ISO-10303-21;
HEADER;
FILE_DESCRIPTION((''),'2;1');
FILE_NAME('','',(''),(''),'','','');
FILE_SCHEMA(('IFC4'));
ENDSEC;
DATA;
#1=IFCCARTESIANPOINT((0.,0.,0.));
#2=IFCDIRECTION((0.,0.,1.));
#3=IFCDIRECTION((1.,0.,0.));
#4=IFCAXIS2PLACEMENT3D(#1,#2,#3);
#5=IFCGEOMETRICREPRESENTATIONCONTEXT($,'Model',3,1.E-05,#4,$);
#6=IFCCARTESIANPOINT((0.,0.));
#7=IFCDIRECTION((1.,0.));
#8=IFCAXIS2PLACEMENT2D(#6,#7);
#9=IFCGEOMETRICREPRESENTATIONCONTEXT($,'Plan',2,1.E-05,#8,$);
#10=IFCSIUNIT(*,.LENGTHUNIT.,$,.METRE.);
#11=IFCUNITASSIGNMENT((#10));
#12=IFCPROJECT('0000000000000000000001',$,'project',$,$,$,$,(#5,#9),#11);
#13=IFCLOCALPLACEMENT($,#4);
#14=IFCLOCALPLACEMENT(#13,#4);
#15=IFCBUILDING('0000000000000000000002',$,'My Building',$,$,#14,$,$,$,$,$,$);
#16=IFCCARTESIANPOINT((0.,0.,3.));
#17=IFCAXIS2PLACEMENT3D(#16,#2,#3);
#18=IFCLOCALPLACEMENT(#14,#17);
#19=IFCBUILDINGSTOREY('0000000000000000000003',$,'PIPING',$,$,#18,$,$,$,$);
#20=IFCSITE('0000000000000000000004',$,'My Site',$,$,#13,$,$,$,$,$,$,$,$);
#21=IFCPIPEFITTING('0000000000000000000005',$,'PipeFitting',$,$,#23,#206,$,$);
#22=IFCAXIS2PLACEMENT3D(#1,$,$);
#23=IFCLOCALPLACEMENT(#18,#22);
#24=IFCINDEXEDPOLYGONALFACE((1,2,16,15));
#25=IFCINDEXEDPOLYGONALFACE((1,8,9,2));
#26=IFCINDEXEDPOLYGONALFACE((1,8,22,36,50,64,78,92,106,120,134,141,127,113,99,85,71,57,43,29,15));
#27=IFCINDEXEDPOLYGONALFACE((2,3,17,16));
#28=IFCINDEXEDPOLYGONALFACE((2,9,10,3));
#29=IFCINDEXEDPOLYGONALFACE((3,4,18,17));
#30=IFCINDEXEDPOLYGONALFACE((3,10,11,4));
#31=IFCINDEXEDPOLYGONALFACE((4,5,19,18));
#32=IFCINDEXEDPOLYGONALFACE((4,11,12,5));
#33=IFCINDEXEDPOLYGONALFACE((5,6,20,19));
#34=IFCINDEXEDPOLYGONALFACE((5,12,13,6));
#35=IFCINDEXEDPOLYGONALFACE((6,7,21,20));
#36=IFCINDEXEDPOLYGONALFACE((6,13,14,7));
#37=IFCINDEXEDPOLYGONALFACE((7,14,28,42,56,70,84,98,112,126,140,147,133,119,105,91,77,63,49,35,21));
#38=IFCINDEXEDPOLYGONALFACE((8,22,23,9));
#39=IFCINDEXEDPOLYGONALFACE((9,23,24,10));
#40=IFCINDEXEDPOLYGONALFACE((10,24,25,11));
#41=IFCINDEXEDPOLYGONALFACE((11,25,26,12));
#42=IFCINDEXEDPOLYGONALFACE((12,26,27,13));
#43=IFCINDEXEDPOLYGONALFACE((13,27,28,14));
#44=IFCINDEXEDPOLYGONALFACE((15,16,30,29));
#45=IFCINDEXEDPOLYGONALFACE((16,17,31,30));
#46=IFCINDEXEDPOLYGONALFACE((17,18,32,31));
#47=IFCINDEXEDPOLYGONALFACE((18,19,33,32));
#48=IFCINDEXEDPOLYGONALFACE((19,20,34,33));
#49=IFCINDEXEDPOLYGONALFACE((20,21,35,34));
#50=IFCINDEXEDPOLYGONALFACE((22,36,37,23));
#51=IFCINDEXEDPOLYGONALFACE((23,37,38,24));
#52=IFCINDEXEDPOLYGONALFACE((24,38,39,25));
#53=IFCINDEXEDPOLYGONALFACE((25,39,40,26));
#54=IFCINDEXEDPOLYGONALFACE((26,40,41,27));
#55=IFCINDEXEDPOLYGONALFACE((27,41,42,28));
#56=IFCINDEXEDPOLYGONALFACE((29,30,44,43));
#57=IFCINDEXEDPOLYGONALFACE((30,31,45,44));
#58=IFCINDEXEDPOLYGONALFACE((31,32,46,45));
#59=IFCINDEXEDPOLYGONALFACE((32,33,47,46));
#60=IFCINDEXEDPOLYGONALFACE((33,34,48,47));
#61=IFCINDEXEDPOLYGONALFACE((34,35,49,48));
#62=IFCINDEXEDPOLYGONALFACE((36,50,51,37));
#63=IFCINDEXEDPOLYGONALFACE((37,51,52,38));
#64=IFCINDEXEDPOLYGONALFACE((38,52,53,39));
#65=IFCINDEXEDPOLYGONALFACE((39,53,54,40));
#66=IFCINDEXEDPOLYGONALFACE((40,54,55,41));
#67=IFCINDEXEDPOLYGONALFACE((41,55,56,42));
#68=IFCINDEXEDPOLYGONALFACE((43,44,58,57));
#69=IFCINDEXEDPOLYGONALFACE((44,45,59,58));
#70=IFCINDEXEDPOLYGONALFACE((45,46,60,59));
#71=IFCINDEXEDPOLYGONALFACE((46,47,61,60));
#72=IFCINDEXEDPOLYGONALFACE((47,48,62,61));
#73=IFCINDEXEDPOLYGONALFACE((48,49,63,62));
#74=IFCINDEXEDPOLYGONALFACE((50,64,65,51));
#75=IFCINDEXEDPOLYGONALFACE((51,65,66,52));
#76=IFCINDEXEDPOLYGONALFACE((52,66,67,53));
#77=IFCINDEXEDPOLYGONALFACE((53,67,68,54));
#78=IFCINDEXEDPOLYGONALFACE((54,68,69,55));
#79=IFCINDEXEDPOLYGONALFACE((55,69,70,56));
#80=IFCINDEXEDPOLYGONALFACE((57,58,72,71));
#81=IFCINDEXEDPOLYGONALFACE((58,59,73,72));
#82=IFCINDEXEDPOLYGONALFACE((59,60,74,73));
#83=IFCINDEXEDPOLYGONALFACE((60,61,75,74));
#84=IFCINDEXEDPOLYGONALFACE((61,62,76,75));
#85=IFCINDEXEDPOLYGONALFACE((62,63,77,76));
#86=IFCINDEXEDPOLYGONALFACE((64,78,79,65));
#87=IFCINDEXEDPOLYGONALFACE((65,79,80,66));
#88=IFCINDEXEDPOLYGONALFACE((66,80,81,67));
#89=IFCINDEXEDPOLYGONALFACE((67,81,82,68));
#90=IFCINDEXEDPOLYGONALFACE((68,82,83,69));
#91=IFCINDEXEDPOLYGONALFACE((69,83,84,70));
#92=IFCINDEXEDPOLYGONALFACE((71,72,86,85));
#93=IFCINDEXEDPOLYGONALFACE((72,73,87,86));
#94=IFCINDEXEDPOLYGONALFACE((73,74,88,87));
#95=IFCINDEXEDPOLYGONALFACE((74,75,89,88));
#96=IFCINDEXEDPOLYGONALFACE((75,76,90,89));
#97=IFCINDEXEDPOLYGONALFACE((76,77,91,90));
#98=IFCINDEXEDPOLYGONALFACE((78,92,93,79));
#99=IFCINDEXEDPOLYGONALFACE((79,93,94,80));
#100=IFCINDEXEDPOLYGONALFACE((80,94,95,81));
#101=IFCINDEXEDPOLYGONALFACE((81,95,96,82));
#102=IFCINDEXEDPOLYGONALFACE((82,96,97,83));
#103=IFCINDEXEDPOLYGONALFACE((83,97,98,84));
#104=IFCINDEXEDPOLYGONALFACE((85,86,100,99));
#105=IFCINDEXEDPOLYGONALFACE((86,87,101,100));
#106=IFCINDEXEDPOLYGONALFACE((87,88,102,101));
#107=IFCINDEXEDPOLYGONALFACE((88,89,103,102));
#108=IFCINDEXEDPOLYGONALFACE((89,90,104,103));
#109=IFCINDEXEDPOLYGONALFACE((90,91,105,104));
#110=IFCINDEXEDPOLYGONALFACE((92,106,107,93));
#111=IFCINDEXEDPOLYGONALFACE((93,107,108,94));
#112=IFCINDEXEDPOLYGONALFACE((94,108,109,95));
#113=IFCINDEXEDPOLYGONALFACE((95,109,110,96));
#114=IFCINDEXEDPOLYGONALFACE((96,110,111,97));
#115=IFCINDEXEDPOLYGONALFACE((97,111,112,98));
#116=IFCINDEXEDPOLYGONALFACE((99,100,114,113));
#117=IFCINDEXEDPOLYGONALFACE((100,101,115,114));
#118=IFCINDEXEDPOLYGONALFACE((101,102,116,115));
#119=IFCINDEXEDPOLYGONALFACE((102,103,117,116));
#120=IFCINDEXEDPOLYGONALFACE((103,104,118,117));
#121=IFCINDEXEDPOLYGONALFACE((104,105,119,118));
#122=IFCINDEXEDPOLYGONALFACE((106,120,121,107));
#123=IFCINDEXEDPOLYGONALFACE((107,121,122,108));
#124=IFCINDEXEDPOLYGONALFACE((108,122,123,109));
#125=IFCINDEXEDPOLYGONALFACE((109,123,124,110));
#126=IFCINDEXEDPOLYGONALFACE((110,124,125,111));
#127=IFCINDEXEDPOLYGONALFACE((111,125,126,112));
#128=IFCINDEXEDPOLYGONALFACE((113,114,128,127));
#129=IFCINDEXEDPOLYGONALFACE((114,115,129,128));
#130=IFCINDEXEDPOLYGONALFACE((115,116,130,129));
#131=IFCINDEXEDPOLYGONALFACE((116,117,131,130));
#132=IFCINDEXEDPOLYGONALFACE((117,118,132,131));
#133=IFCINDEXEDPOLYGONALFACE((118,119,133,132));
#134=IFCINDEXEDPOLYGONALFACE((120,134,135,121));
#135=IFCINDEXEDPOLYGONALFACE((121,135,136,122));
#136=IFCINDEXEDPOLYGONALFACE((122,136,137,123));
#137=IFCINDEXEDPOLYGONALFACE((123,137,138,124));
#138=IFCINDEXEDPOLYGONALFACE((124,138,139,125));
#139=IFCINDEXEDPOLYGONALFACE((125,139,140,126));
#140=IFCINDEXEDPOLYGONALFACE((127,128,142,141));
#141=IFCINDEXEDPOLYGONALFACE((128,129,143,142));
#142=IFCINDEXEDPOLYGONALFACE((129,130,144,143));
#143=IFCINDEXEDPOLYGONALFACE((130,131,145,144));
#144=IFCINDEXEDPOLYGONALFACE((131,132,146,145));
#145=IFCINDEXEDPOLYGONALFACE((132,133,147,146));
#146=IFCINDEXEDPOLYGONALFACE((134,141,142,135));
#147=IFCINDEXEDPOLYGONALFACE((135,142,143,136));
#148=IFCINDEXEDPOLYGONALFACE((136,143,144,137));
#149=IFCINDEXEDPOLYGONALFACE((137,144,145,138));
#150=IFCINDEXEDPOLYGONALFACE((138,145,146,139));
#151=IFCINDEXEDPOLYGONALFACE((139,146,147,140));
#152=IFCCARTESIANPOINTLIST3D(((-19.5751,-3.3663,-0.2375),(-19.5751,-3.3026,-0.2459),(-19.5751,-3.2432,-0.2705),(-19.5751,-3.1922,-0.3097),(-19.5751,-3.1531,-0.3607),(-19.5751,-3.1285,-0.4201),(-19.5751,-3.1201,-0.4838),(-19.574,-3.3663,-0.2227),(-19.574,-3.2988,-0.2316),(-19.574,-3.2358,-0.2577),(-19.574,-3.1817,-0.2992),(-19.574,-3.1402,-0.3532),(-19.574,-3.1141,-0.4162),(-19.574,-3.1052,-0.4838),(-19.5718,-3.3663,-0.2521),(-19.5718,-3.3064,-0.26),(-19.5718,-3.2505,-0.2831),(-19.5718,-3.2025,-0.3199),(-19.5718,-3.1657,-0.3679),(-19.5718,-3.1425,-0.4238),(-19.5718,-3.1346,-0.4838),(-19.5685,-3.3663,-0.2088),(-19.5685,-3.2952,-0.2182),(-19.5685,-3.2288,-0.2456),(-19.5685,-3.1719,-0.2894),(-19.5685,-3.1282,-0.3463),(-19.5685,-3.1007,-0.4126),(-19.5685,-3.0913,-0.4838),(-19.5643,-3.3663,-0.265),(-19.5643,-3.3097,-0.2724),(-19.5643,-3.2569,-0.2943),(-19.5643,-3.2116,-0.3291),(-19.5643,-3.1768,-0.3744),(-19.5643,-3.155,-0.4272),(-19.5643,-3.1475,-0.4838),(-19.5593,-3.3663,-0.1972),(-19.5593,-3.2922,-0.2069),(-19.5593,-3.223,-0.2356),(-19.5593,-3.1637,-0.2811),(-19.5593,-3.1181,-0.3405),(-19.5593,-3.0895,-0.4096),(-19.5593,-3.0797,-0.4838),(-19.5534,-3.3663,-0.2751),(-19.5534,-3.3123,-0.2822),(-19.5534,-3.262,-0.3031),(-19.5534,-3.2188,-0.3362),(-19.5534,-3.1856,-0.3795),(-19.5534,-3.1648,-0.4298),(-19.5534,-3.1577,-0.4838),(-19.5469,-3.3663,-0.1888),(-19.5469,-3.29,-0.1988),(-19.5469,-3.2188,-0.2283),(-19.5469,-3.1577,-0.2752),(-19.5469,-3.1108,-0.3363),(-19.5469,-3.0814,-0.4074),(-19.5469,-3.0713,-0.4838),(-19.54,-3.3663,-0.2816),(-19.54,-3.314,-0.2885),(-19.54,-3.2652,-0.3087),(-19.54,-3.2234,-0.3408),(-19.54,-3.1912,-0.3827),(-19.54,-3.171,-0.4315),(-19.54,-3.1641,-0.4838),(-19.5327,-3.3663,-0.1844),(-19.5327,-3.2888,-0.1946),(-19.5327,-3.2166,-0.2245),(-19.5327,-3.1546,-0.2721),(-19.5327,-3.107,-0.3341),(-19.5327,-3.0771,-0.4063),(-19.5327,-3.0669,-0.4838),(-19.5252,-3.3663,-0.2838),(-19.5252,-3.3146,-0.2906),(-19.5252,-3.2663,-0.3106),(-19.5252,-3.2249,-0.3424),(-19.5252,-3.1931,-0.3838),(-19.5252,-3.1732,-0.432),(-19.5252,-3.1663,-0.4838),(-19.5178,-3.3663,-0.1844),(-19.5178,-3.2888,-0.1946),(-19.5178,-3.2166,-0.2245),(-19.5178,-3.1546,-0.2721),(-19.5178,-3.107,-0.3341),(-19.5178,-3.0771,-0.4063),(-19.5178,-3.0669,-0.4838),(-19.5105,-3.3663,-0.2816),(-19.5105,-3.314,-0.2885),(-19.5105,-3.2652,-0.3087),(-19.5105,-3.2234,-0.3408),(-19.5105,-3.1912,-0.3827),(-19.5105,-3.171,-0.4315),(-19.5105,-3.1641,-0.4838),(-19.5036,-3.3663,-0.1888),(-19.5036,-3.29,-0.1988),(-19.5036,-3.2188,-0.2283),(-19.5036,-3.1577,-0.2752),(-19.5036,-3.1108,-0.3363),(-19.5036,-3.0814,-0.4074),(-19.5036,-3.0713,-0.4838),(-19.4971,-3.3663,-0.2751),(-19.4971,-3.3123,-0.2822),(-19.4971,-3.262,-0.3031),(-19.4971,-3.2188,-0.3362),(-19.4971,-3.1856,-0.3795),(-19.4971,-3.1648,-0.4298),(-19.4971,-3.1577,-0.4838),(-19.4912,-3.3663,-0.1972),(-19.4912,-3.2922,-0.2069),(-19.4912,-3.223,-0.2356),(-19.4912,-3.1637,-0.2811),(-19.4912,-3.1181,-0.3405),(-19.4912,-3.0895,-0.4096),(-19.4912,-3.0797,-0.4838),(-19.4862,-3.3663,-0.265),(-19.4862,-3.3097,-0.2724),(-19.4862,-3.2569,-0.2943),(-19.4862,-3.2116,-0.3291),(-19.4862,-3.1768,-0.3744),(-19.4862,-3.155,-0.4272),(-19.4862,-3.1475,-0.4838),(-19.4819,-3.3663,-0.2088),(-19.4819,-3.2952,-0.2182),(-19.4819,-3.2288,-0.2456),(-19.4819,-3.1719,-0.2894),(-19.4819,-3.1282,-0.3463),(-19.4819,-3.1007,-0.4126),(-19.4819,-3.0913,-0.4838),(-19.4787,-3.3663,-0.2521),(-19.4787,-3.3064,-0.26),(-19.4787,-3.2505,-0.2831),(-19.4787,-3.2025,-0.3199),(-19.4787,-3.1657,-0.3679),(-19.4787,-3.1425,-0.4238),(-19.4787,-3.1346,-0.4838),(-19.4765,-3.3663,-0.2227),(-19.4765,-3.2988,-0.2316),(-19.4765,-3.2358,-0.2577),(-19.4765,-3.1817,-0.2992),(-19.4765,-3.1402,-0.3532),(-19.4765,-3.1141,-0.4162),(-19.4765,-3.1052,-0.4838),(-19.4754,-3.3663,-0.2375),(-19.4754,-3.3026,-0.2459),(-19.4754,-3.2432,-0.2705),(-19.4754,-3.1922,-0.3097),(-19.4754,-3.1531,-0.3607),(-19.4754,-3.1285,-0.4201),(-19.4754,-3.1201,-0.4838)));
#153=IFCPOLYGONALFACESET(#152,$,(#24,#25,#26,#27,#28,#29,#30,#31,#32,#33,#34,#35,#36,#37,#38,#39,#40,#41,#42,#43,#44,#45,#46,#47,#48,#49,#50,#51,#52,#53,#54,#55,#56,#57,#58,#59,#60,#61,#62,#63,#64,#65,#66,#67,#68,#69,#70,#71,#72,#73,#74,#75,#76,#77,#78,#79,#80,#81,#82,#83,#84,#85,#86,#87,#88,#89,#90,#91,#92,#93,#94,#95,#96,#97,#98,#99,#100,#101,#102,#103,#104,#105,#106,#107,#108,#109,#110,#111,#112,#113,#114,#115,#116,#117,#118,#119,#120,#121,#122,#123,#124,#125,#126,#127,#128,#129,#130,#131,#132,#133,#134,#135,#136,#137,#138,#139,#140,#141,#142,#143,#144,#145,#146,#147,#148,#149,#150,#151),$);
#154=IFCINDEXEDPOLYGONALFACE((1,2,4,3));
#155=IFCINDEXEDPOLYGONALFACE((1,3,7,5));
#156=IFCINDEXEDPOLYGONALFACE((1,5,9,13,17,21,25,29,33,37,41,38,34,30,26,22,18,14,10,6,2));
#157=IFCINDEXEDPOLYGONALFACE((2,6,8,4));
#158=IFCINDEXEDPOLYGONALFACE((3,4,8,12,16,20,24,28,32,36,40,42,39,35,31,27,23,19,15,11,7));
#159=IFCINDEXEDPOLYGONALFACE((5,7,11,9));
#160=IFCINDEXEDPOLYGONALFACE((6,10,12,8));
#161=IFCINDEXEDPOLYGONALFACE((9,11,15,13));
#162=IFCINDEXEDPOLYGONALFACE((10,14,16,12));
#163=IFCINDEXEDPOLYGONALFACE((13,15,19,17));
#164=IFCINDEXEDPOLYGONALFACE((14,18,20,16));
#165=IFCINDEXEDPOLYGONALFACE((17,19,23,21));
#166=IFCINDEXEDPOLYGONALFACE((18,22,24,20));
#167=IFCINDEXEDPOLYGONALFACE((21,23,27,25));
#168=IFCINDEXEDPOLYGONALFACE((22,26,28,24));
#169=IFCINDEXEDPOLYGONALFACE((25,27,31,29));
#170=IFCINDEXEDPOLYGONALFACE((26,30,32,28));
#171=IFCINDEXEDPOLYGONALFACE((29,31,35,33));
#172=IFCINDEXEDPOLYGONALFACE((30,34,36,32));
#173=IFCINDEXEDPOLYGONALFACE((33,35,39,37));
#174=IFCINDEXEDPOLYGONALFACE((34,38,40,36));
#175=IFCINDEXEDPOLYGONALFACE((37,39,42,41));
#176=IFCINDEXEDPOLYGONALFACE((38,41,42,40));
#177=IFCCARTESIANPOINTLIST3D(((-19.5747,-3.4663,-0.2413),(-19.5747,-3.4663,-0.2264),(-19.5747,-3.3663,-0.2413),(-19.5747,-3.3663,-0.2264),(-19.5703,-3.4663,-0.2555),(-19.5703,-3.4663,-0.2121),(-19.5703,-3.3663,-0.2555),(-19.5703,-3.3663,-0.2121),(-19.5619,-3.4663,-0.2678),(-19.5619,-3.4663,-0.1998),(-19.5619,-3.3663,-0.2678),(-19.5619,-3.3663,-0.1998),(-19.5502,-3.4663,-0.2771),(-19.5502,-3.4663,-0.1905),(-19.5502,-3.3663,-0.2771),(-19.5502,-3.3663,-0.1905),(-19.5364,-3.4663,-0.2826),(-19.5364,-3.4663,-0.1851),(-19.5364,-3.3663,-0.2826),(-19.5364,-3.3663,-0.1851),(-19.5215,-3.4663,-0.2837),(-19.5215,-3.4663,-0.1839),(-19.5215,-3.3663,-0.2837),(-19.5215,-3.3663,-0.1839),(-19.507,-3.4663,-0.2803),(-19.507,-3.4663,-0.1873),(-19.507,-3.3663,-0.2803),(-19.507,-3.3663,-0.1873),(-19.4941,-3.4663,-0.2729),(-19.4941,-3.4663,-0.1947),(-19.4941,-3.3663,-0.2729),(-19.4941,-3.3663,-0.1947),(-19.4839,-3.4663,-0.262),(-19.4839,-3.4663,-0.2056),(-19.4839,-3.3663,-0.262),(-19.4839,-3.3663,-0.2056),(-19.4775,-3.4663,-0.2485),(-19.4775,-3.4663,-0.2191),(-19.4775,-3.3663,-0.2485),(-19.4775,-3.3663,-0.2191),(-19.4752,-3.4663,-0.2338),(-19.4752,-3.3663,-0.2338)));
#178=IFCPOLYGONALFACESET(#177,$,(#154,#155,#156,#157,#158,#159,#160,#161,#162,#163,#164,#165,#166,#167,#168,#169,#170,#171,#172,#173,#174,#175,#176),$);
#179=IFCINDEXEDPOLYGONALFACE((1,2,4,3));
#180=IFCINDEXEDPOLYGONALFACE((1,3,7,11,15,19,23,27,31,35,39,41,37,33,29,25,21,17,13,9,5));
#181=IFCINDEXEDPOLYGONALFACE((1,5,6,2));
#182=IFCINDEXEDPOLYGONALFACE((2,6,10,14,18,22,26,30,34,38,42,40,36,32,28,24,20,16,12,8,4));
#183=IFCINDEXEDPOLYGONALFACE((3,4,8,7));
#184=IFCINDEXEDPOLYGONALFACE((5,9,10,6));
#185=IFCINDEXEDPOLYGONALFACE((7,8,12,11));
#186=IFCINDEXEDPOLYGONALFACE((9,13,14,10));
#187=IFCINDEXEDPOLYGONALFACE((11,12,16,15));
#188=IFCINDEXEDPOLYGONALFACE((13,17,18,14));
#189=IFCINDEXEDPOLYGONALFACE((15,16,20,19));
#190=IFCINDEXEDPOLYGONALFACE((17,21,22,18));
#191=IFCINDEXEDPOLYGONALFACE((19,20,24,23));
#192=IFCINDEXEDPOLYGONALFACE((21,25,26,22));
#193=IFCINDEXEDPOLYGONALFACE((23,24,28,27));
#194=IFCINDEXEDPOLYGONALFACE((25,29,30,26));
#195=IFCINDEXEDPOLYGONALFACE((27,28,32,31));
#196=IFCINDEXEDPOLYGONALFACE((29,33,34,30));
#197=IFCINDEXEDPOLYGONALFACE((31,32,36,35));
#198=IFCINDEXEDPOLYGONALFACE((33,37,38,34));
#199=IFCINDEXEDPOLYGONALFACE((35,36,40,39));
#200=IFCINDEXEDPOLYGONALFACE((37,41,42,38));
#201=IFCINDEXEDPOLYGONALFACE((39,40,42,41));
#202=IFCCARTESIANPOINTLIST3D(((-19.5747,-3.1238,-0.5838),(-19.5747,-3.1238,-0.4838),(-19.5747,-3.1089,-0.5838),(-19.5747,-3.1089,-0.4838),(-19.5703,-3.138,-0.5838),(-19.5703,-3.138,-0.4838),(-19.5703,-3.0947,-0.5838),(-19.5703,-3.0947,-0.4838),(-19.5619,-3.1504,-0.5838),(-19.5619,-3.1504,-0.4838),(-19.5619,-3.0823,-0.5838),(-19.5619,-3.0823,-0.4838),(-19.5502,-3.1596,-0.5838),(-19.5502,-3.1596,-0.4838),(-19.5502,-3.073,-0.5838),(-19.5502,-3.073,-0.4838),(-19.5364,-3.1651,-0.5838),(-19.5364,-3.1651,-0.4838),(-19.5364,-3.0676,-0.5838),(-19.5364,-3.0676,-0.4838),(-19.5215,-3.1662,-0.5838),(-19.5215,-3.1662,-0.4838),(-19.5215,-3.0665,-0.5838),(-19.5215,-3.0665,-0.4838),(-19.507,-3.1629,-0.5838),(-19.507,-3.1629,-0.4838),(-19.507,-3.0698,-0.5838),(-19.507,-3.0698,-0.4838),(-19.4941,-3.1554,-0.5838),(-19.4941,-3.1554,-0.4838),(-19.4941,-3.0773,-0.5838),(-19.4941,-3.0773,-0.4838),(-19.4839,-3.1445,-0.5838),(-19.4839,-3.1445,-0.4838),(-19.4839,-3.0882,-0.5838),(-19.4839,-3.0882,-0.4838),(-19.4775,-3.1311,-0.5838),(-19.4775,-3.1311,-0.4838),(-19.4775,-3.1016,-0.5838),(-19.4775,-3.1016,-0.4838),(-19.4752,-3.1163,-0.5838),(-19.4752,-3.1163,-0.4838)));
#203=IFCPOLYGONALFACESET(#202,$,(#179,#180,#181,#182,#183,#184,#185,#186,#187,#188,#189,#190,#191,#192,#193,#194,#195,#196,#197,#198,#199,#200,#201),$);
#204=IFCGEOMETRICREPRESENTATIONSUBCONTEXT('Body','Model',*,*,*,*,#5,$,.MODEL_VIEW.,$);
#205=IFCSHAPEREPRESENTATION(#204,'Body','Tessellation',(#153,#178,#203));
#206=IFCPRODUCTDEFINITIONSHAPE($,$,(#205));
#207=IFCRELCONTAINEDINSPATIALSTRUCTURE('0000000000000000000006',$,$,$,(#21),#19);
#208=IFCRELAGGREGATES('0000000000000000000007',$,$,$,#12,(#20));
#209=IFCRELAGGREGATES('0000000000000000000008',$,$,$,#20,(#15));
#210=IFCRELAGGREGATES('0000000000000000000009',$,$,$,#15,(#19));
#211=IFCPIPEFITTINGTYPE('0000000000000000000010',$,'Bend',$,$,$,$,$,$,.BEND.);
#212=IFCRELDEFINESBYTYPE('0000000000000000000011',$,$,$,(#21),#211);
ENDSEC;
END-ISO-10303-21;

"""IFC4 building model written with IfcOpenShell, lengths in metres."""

from ifc_helpers import new_model, entity, si_unit, frame, origin_with_axes, origin_2d_with_axis, place, context, subcontext, project, spatial, circle, extrude, source, transform, mapped, type_object, type_shapes, element, save


model = new_model("IFC4")

# Units and contexts
model_context = context("Model", 3, precision=1e-05, world=origin_with_axes())
plan_context = context("Plan", 2, precision=1e-05, world=origin_2d_with_axis())
body_context = subcontext(model_context, "Body", "Model", "MODEL_VIEW")
ifc_project = project(units=[si_unit("LENGTHUNIT", "METRE")], contexts=[model_context, plan_context])

# Site, building, storey
site_placement = place(None, origin_with_axes())
site = spatial("IfcSite", under=ifc_project, at=site_placement, Name="My Site")
building_placement = place(site_placement, origin_with_axes())
building = spatial("IfcBuilding", under=site, at=building_placement, Name="My Building")
storey_placement = place(building_placement, frame((0.0, 0.0, 3.0), z_axis=(0.0, 0.0, 1.0), x_axis=(1.0, 0.0, 0.0)))
storey = spatial("IfcBuildingStorey", under=building, at=storey_placement, Name="PIPING")

# Pipe fitting
pipe_fitting_type = type_object("IfcPipeFittingType", Name="Bend", PredefinedType="BEND")
shared_shape = source(origin_with_axes(), body_context, "Body", "SolidModel", [
    entity("IfcSweptDiskSolid", entity("IfcIndexedPolyCurve", entity("IfcCartesianPointList3D", [[0.0, 0.0, -0.1], [0.0, -0.0732, -0.2768], [0.0, -0.25, -0.35]]), [entity("IfcArcIndex", [1, 2, 3])]), 0.05),
    extrude(circle(Radius=0.05), origin_with_axes(), (0.0, 0.0, -1.0), 0.1),
    extrude(circle(Radius=0.05), frame((0.0, -0.25, -0.35), z_axis=(0.0, -1.0, 0.0), x_axis=(1.0, 0.0, 0.0)), (0.0, 0.0, 1.0), 0.1),
])
type_shapes(pipe_fitting_type, [shared_shape])
for number, where, z_axis, x_axis, name in (
    (1, (-19.5252, -3.4663, -0.2338), (0.0, -1.0, 0.0), (1.0, 0.0, 0.0), "PipeFitting"),
):
    element("IfcPipeFitting", number, at=place(storey_placement, frame(where, z_axis=z_axis, x_axis=x_axis)), inside=storey, type_object=pipe_fitting_type, Name=name, context=body_context, shape_type="MappedRepresentation", body=[
        mapped(shared_shape, transform((0.0, 0.0, 0.0), x_axis=(1.0, 0.0, 0.0), y_axis=(0.0, 1.0, 0.0), z_axis=(0.0, 0.0, 1.0), scale=1.0)),
    ])

save(model, "model.ifc")
